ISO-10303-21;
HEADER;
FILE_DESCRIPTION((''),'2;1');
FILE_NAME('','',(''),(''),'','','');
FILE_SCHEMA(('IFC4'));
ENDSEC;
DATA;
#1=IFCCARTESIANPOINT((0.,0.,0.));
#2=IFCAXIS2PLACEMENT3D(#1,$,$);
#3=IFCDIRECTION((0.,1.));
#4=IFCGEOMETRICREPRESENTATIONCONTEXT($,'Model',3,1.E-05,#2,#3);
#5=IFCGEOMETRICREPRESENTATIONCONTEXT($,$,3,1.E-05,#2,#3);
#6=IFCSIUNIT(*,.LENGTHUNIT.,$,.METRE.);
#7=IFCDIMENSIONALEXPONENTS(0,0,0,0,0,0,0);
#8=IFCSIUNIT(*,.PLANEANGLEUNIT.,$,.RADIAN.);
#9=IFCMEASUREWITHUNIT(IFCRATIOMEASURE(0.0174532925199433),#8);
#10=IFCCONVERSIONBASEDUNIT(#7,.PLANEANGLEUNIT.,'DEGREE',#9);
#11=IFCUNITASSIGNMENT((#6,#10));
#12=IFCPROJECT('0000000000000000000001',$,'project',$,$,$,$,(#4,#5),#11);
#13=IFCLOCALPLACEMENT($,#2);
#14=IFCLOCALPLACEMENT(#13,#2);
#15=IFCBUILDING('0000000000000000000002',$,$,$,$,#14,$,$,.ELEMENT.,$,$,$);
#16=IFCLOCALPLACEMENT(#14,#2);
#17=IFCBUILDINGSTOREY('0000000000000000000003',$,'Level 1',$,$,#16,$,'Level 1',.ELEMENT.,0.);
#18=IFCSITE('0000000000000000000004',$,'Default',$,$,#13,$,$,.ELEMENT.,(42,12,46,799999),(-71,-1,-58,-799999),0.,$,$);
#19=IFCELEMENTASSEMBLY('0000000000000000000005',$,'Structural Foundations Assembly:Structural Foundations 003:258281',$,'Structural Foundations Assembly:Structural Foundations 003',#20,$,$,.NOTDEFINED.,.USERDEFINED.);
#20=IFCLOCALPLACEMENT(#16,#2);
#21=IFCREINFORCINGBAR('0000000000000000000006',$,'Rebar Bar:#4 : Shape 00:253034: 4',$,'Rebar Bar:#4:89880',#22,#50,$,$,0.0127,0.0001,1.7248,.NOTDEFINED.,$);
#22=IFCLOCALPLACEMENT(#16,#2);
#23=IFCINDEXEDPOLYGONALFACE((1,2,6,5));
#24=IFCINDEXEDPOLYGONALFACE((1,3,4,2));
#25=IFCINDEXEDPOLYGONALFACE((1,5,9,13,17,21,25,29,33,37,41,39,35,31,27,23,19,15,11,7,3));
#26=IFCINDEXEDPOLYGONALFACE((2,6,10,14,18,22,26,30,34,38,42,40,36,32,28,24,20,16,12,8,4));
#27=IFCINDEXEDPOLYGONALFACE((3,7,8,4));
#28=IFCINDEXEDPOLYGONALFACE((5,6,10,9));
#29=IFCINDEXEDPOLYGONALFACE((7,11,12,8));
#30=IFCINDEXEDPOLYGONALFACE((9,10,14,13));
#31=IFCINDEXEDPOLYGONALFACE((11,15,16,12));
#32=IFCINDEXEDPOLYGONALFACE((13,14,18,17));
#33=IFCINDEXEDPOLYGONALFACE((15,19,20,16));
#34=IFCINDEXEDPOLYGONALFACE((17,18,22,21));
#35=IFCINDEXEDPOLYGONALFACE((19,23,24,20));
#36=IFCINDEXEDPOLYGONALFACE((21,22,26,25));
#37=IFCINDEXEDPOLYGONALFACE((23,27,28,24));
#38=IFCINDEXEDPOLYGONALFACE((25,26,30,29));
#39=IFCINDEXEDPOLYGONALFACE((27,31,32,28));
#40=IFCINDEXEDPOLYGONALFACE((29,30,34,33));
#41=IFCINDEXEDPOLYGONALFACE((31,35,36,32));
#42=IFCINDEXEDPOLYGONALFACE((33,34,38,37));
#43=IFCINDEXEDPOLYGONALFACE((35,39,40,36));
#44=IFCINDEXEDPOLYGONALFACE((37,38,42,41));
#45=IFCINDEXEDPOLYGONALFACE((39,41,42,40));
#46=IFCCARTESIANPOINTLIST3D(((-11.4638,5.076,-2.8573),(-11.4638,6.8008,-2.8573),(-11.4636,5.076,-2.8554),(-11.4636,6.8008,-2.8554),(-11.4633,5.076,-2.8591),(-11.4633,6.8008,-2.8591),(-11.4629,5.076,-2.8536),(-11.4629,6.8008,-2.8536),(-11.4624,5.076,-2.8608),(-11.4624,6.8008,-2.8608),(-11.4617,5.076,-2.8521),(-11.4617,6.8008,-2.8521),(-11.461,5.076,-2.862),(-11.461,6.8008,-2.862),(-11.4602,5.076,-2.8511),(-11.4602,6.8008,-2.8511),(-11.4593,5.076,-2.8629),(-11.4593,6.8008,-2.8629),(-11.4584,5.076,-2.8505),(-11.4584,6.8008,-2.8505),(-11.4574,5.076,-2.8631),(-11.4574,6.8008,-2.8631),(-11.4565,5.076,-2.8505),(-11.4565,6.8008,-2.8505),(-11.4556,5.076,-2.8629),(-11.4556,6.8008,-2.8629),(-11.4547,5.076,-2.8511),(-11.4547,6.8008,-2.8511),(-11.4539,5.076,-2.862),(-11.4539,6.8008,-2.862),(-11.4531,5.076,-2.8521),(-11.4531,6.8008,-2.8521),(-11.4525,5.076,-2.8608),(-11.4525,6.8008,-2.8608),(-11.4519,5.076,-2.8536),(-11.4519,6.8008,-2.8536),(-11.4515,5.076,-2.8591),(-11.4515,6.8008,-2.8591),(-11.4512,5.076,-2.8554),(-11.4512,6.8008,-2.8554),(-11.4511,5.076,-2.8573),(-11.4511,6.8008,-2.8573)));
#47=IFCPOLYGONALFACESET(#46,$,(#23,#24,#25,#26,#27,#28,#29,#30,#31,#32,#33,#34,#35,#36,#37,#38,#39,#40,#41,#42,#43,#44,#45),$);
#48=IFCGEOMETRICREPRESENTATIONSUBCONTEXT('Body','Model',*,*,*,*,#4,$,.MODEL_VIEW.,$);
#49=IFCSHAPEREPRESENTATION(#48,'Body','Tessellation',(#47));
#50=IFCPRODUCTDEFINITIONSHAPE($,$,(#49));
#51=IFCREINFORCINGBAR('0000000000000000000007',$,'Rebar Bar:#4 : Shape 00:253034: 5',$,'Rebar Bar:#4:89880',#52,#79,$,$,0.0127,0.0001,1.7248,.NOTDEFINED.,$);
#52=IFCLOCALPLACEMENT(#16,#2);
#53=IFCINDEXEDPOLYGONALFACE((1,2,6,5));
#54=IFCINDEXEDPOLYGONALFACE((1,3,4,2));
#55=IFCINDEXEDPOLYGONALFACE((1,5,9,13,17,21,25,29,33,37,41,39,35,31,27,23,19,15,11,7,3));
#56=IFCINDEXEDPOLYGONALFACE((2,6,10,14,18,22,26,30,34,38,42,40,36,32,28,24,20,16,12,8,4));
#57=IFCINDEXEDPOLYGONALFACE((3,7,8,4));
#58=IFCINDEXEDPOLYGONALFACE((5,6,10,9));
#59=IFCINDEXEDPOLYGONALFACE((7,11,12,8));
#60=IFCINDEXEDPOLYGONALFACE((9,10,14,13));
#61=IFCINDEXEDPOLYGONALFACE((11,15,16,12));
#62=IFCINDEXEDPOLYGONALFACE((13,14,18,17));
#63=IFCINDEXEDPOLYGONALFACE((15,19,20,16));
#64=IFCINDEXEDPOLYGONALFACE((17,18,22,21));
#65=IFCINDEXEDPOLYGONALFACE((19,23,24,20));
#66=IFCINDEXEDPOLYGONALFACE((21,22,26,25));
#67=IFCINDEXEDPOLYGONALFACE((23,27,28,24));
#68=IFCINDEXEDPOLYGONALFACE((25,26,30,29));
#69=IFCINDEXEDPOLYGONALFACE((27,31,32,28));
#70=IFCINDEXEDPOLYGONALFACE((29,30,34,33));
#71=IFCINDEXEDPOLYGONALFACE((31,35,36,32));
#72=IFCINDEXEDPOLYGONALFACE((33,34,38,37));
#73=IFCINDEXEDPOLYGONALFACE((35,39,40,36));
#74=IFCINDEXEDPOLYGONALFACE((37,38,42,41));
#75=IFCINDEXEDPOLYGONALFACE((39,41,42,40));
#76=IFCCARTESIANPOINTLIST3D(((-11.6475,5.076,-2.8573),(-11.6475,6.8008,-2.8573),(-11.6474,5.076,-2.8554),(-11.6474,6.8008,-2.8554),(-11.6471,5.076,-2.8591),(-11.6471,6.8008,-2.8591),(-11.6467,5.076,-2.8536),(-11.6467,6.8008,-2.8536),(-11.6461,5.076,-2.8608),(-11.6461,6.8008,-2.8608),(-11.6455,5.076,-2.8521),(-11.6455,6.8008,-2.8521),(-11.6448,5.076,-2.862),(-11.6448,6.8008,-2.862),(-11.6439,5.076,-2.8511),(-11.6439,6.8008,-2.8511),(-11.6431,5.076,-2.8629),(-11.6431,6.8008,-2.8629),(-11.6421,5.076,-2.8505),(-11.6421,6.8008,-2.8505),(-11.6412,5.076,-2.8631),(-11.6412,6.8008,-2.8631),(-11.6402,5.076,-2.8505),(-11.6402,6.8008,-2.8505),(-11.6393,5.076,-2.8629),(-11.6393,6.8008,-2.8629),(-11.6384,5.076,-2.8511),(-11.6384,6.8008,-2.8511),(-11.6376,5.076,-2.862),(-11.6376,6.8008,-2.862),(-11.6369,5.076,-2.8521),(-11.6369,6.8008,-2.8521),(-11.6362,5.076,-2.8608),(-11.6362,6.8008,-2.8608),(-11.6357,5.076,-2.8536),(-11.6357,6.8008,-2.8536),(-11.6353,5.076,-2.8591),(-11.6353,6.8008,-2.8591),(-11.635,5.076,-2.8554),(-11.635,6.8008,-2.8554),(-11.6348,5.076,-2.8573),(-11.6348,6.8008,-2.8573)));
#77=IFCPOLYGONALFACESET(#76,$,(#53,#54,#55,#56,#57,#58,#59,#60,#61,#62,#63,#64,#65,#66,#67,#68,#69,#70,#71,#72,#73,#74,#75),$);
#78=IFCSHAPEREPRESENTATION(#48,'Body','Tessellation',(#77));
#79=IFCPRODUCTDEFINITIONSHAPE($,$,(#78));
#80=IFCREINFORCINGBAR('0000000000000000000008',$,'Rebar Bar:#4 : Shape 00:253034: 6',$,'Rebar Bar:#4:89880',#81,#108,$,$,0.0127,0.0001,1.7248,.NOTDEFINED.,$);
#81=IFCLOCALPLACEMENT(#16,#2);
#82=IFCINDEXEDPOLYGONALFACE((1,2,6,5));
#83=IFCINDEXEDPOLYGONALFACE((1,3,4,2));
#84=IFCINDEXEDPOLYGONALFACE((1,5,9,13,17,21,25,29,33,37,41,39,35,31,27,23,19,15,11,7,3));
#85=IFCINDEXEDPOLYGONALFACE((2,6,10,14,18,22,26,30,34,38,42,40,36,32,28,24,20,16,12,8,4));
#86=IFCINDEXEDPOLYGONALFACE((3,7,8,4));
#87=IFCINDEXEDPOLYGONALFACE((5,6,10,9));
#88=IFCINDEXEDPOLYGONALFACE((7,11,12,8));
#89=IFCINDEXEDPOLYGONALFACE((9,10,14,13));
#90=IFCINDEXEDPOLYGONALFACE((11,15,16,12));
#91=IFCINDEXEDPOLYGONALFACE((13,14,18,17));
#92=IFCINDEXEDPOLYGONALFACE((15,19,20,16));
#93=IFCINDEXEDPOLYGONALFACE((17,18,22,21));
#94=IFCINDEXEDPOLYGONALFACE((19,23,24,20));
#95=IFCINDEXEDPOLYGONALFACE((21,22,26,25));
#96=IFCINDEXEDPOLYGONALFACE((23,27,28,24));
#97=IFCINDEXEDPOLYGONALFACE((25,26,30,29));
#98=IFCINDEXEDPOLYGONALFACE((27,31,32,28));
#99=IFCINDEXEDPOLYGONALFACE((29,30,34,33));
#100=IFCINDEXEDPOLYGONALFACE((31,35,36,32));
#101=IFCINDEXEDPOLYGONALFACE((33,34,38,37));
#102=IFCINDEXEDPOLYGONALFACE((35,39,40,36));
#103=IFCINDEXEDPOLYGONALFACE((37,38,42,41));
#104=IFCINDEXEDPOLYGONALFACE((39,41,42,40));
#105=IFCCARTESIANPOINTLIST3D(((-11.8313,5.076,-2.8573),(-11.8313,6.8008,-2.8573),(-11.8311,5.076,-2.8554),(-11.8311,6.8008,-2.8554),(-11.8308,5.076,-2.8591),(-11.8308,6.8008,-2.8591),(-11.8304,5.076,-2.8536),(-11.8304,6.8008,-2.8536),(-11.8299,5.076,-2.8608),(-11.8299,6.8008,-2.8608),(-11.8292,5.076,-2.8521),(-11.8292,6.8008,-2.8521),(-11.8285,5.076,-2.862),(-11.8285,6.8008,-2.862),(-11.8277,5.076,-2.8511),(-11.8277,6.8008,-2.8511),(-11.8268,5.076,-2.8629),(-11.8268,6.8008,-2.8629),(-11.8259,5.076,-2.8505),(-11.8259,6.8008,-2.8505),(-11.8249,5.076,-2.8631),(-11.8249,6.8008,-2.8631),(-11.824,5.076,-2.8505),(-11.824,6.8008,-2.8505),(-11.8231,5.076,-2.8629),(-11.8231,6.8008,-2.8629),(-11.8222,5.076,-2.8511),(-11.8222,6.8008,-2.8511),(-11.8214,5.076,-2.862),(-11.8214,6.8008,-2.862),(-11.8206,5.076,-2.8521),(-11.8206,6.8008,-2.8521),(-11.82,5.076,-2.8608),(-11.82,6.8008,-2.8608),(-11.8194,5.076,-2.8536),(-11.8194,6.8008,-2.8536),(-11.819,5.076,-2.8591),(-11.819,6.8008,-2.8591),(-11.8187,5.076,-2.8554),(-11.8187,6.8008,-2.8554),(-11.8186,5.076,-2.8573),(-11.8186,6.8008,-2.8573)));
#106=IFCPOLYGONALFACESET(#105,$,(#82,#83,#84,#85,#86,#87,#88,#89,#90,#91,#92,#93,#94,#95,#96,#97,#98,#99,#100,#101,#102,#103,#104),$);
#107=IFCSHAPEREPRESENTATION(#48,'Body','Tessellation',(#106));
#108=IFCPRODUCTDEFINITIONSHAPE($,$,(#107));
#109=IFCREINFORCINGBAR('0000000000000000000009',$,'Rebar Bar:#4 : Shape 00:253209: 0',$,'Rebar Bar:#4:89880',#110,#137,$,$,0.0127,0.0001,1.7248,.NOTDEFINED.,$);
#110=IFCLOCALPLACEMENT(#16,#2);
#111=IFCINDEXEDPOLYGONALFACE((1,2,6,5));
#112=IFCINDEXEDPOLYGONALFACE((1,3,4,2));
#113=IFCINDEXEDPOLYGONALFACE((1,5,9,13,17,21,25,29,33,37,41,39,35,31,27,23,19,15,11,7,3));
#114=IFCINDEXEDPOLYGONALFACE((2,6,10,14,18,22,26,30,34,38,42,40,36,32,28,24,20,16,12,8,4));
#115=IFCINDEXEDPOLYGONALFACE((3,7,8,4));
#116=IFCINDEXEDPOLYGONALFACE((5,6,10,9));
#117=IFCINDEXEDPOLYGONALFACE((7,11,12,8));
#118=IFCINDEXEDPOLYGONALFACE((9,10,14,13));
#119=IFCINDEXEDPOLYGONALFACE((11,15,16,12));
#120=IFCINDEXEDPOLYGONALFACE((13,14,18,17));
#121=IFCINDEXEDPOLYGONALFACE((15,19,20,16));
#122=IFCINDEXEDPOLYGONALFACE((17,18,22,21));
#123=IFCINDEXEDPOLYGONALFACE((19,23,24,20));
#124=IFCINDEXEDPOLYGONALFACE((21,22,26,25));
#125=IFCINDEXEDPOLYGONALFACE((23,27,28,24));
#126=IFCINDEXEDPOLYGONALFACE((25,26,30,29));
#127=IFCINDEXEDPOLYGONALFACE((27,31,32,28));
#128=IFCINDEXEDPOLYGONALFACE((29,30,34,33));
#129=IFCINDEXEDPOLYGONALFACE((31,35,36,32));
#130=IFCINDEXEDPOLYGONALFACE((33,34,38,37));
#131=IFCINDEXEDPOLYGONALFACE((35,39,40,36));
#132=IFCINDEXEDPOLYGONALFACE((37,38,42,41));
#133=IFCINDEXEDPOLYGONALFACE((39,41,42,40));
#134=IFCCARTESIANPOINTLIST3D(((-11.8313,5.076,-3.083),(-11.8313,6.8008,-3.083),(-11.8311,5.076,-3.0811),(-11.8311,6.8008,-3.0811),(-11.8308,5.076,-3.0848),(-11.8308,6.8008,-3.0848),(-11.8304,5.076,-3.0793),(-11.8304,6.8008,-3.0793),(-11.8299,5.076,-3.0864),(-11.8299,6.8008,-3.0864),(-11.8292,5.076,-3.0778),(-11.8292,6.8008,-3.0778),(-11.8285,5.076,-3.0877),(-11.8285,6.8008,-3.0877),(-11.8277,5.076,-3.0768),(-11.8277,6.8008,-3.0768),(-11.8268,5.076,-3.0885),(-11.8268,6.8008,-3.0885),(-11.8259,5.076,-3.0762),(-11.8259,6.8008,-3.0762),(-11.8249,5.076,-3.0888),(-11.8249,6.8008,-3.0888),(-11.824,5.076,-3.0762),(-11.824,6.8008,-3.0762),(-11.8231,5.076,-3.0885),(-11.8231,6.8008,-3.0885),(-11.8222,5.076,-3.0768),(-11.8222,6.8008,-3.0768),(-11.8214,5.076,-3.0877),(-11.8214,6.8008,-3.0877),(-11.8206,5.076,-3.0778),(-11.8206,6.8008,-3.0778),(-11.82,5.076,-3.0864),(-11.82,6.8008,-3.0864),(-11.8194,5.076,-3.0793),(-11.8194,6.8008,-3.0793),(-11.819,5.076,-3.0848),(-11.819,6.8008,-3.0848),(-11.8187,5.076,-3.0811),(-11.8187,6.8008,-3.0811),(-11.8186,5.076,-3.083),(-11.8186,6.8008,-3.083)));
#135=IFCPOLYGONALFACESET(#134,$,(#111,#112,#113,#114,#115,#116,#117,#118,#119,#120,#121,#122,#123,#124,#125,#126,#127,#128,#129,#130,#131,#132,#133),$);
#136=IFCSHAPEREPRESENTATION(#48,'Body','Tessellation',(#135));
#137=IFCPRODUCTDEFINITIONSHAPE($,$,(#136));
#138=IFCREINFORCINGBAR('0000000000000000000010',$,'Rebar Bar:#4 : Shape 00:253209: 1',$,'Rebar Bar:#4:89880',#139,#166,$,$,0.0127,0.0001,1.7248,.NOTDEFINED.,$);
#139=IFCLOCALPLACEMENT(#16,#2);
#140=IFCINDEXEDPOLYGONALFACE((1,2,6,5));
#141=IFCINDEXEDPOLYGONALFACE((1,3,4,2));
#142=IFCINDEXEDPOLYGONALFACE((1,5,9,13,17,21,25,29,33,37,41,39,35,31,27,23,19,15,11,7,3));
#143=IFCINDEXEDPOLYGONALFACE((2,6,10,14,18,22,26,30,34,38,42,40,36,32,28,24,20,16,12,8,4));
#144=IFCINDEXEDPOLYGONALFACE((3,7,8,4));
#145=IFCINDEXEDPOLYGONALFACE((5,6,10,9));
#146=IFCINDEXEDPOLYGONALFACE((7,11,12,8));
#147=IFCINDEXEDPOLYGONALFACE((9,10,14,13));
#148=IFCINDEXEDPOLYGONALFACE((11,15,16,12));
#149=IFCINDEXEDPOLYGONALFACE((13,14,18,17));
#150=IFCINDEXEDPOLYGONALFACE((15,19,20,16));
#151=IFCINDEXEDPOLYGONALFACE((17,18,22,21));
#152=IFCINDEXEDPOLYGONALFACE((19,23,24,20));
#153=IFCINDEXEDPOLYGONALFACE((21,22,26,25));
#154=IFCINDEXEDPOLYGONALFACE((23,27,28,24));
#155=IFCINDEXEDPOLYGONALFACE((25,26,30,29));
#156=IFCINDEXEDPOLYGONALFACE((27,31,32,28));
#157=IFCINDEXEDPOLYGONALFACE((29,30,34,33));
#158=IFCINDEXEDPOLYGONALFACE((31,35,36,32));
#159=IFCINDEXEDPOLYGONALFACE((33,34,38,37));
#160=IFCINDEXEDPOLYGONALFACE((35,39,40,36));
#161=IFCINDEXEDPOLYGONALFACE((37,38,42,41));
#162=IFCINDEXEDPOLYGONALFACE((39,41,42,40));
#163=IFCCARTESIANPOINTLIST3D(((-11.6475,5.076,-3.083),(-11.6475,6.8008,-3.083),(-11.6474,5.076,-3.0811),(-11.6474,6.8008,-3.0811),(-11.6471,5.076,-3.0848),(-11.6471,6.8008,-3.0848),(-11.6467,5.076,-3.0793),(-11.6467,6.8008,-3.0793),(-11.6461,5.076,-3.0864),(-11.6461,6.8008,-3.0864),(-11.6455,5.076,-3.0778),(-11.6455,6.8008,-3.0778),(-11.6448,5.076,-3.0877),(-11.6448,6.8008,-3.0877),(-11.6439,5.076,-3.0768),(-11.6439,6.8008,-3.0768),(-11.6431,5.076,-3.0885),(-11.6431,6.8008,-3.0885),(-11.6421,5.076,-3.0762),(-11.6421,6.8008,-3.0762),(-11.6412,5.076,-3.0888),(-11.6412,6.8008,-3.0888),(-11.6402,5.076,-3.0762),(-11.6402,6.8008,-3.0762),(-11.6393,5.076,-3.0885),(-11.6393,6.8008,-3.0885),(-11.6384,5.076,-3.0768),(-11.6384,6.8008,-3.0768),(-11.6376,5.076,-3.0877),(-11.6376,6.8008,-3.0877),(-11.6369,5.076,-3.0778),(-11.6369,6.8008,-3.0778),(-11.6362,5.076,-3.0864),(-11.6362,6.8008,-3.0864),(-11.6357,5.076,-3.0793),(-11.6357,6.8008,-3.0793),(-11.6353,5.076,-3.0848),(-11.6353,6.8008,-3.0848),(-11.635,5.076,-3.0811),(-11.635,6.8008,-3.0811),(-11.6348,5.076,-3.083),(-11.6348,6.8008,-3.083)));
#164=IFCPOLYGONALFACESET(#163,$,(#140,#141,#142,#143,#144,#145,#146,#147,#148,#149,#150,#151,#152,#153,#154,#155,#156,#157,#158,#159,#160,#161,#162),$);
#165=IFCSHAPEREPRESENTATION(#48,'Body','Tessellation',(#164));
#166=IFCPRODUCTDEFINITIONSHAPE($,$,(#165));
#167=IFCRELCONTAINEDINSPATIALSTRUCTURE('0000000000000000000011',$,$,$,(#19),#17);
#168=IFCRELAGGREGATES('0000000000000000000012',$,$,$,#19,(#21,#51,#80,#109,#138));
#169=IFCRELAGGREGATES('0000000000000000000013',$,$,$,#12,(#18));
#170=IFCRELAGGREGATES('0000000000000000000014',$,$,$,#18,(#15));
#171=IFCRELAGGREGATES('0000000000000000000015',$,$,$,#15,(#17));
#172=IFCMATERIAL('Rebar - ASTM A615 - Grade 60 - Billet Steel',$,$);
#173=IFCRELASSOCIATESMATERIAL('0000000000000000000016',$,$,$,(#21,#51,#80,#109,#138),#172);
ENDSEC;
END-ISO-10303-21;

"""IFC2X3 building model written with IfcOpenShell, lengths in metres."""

from ifc_helpers import new_model, entity, si_unit, converted_unit, direction, origin, place, context, subcontext, project, spatial, material, element, aggregate, save


model = new_model("IFC2X3")

# Units and contexts
model_context = context("Model", 3, precision=1e-05, world=origin(), true_north=direction((0.0, 1.0)))
context_of_model = context(None, 3, precision=1e-05, world=origin(), true_north=direction((0.0, 1.0)))
body_context = subcontext(model_context, "Body", "Model", "MODEL_VIEW")
ifc_project = project(units=[si_unit("LENGTHUNIT", "METRE"), converted_unit("PLANEANGLEUNIT", "DEGREE", entity("IfcRatioMeasure", 0.0174532925199433), si_unit("PLANEANGLEUNIT", "RADIAN"), dimensions=[0, 0, 0, 0, 0, 0, 0])], contexts=[model_context, context_of_model])

# Site, building, storey
site_placement = place(None, origin())
site = spatial("IfcSite", under=ifc_project, at=site_placement, Name="Default", CompositionType="ELEMENT", RefLatitude=(42, 12, 46, 799999), RefLongitude=(-71, -1, -58, -799999), RefElevation=0.0)
building_placement = place(site_placement, origin())
building = spatial("IfcBuilding", under=site, at=building_placement, CompositionType="ELEMENT")
storey_placement = place(building_placement, origin())
storey = spatial("IfcBuildingStorey", under=building, at=storey_placement, Name="Level 1", LongName="Level 1", CompositionType="ELEMENT", Elevation=0.0)

# Element assembly, reinforcing bars
assembly_1_placement = place(storey_placement, origin())
assembly_1 = element("IfcElementAssembly", 1, at=assembly_1_placement, inside=storey, Name="Structural Foundations Assembly:Structural Foundations 003:258281", ObjectType="Structural Foundations Assembly:Structural Foundations 003", AssemblyPlace="NOTDEFINED", PredefinedType="USERDEFINED")
ifc_material = material(Name="Rebar - ASTM A615 - Grade 60 - Billet Steel")
reinforcing_bar_1_placement = place(assembly_1_placement, origin())
reinforcing_bar_1 = element("IfcReinforcingBar", 2, at=reinforcing_bar_1_placement, material=ifc_material, Name="Rebar Bar:#4 : Shape 00:253034: 4", ObjectType="Rebar Bar:#4:89880", BarLength=1.7248, BarRole="NOTDEFINED", CrossSectionArea=0.0001, NominalDiameter=0.0127, context=body_context, shape_type="AdvancedSweptSolid", body=[
    entity("IfcSweptDiskSolid", entity("IfcCompositeCurve", [entity("IfcCompositeCurveSegment", "CONTINUOUS", True, entity("IfcPolyline", [entity("IfcCartesianPoint", [-11.4574, 6.8008, -2.8568]), entity("IfcCartesianPoint", [-11.4574, 5.076, -2.8568])]))], False), 0.0063, None, 0.0, 1.0),
])
reinforcing_bar_2_placement = place(assembly_1_placement, origin())
reinforcing_bar_2 = element("IfcReinforcingBar", 3, at=reinforcing_bar_2_placement, material=ifc_material, Name="Rebar Bar:#4 : Shape 00:253034: 5", ObjectType="Rebar Bar:#4:89880", BarLength=1.7248, BarRole="NOTDEFINED", CrossSectionArea=0.0001, NominalDiameter=0.0127, context=body_context, shape_type="AdvancedSweptSolid", body=[
    entity("IfcSweptDiskSolid", entity("IfcCompositeCurve", [entity("IfcCompositeCurveSegment", "CONTINUOUS", True, entity("IfcPolyline", [entity("IfcCartesianPoint", [-11.6412, 6.8008, -2.8568]), entity("IfcCartesianPoint", [-11.6412, 5.076, -2.8568])]))], False), 0.0063, None, 0.0, 1.0),
])
reinforcing_bar_3_placement = place(assembly_1_placement, origin())
reinforcing_bar_3 = element("IfcReinforcingBar", 4, at=reinforcing_bar_3_placement, material=ifc_material, Name="Rebar Bar:#4 : Shape 00:253034: 6", ObjectType="Rebar Bar:#4:89880", BarLength=1.7248, BarRole="NOTDEFINED", CrossSectionArea=0.0001, NominalDiameter=0.0127, context=body_context, shape_type="AdvancedSweptSolid", body=[
    entity("IfcSweptDiskSolid", entity("IfcCompositeCurve", [entity("IfcCompositeCurveSegment", "CONTINUOUS", True, entity("IfcPolyline", [entity("IfcCartesianPoint", [-11.8249, 6.8008, -2.8568]), entity("IfcCartesianPoint", [-11.8249, 5.076, -2.8568])]))], False), 0.0063, None, 0.0, 1.0),
])
reinforcing_bar_4_placement = place(assembly_1_placement, origin())
reinforcing_bar_4 = element("IfcReinforcingBar", 5, at=reinforcing_bar_4_placement, material=ifc_material, Name="Rebar Bar:#4 : Shape 00:253209: 0", ObjectType="Rebar Bar:#4:89880", BarLength=1.7248, BarRole="NOTDEFINED", CrossSectionArea=0.0001, NominalDiameter=0.0127, context=body_context, shape_type="AdvancedSweptSolid", body=[
    entity("IfcSweptDiskSolid", entity("IfcCompositeCurve", [entity("IfcCompositeCurveSegment", "CONTINUOUS", True, entity("IfcPolyline", [entity("IfcCartesianPoint", [-11.8249, 6.8008, -3.0825]), entity("IfcCartesianPoint", [-11.8249, 5.076, -3.0825])]))], False), 0.0063, None, 0.0, 1.0),
])
reinforcing_bar_5_placement = place(assembly_1_placement, origin())
reinforcing_bar_5 = element("IfcReinforcingBar", 6, at=reinforcing_bar_5_placement, material=ifc_material, Name="Rebar Bar:#4 : Shape 00:253209: 1", ObjectType="Rebar Bar:#4:89880", BarLength=1.7248, BarRole="NOTDEFINED", CrossSectionArea=0.0001, NominalDiameter=0.0127, context=body_context, shape_type="AdvancedSweptSolid", body=[
    entity("IfcSweptDiskSolid", entity("IfcCompositeCurve", [entity("IfcCompositeCurveSegment", "CONTINUOUS", True, entity("IfcPolyline", [entity("IfcCartesianPoint", [-11.6412, 6.8008, -3.0825]), entity("IfcCartesianPoint", [-11.6412, 5.076, -3.0825])]))], False), 0.0063, None, 0.0, 1.0),
])
aggregate(assembly_1, [reinforcing_bar_1, reinforcing_bar_2, reinforcing_bar_3, reinforcing_bar_4, reinforcing_bar_5])

save(model, "model.ifc")
